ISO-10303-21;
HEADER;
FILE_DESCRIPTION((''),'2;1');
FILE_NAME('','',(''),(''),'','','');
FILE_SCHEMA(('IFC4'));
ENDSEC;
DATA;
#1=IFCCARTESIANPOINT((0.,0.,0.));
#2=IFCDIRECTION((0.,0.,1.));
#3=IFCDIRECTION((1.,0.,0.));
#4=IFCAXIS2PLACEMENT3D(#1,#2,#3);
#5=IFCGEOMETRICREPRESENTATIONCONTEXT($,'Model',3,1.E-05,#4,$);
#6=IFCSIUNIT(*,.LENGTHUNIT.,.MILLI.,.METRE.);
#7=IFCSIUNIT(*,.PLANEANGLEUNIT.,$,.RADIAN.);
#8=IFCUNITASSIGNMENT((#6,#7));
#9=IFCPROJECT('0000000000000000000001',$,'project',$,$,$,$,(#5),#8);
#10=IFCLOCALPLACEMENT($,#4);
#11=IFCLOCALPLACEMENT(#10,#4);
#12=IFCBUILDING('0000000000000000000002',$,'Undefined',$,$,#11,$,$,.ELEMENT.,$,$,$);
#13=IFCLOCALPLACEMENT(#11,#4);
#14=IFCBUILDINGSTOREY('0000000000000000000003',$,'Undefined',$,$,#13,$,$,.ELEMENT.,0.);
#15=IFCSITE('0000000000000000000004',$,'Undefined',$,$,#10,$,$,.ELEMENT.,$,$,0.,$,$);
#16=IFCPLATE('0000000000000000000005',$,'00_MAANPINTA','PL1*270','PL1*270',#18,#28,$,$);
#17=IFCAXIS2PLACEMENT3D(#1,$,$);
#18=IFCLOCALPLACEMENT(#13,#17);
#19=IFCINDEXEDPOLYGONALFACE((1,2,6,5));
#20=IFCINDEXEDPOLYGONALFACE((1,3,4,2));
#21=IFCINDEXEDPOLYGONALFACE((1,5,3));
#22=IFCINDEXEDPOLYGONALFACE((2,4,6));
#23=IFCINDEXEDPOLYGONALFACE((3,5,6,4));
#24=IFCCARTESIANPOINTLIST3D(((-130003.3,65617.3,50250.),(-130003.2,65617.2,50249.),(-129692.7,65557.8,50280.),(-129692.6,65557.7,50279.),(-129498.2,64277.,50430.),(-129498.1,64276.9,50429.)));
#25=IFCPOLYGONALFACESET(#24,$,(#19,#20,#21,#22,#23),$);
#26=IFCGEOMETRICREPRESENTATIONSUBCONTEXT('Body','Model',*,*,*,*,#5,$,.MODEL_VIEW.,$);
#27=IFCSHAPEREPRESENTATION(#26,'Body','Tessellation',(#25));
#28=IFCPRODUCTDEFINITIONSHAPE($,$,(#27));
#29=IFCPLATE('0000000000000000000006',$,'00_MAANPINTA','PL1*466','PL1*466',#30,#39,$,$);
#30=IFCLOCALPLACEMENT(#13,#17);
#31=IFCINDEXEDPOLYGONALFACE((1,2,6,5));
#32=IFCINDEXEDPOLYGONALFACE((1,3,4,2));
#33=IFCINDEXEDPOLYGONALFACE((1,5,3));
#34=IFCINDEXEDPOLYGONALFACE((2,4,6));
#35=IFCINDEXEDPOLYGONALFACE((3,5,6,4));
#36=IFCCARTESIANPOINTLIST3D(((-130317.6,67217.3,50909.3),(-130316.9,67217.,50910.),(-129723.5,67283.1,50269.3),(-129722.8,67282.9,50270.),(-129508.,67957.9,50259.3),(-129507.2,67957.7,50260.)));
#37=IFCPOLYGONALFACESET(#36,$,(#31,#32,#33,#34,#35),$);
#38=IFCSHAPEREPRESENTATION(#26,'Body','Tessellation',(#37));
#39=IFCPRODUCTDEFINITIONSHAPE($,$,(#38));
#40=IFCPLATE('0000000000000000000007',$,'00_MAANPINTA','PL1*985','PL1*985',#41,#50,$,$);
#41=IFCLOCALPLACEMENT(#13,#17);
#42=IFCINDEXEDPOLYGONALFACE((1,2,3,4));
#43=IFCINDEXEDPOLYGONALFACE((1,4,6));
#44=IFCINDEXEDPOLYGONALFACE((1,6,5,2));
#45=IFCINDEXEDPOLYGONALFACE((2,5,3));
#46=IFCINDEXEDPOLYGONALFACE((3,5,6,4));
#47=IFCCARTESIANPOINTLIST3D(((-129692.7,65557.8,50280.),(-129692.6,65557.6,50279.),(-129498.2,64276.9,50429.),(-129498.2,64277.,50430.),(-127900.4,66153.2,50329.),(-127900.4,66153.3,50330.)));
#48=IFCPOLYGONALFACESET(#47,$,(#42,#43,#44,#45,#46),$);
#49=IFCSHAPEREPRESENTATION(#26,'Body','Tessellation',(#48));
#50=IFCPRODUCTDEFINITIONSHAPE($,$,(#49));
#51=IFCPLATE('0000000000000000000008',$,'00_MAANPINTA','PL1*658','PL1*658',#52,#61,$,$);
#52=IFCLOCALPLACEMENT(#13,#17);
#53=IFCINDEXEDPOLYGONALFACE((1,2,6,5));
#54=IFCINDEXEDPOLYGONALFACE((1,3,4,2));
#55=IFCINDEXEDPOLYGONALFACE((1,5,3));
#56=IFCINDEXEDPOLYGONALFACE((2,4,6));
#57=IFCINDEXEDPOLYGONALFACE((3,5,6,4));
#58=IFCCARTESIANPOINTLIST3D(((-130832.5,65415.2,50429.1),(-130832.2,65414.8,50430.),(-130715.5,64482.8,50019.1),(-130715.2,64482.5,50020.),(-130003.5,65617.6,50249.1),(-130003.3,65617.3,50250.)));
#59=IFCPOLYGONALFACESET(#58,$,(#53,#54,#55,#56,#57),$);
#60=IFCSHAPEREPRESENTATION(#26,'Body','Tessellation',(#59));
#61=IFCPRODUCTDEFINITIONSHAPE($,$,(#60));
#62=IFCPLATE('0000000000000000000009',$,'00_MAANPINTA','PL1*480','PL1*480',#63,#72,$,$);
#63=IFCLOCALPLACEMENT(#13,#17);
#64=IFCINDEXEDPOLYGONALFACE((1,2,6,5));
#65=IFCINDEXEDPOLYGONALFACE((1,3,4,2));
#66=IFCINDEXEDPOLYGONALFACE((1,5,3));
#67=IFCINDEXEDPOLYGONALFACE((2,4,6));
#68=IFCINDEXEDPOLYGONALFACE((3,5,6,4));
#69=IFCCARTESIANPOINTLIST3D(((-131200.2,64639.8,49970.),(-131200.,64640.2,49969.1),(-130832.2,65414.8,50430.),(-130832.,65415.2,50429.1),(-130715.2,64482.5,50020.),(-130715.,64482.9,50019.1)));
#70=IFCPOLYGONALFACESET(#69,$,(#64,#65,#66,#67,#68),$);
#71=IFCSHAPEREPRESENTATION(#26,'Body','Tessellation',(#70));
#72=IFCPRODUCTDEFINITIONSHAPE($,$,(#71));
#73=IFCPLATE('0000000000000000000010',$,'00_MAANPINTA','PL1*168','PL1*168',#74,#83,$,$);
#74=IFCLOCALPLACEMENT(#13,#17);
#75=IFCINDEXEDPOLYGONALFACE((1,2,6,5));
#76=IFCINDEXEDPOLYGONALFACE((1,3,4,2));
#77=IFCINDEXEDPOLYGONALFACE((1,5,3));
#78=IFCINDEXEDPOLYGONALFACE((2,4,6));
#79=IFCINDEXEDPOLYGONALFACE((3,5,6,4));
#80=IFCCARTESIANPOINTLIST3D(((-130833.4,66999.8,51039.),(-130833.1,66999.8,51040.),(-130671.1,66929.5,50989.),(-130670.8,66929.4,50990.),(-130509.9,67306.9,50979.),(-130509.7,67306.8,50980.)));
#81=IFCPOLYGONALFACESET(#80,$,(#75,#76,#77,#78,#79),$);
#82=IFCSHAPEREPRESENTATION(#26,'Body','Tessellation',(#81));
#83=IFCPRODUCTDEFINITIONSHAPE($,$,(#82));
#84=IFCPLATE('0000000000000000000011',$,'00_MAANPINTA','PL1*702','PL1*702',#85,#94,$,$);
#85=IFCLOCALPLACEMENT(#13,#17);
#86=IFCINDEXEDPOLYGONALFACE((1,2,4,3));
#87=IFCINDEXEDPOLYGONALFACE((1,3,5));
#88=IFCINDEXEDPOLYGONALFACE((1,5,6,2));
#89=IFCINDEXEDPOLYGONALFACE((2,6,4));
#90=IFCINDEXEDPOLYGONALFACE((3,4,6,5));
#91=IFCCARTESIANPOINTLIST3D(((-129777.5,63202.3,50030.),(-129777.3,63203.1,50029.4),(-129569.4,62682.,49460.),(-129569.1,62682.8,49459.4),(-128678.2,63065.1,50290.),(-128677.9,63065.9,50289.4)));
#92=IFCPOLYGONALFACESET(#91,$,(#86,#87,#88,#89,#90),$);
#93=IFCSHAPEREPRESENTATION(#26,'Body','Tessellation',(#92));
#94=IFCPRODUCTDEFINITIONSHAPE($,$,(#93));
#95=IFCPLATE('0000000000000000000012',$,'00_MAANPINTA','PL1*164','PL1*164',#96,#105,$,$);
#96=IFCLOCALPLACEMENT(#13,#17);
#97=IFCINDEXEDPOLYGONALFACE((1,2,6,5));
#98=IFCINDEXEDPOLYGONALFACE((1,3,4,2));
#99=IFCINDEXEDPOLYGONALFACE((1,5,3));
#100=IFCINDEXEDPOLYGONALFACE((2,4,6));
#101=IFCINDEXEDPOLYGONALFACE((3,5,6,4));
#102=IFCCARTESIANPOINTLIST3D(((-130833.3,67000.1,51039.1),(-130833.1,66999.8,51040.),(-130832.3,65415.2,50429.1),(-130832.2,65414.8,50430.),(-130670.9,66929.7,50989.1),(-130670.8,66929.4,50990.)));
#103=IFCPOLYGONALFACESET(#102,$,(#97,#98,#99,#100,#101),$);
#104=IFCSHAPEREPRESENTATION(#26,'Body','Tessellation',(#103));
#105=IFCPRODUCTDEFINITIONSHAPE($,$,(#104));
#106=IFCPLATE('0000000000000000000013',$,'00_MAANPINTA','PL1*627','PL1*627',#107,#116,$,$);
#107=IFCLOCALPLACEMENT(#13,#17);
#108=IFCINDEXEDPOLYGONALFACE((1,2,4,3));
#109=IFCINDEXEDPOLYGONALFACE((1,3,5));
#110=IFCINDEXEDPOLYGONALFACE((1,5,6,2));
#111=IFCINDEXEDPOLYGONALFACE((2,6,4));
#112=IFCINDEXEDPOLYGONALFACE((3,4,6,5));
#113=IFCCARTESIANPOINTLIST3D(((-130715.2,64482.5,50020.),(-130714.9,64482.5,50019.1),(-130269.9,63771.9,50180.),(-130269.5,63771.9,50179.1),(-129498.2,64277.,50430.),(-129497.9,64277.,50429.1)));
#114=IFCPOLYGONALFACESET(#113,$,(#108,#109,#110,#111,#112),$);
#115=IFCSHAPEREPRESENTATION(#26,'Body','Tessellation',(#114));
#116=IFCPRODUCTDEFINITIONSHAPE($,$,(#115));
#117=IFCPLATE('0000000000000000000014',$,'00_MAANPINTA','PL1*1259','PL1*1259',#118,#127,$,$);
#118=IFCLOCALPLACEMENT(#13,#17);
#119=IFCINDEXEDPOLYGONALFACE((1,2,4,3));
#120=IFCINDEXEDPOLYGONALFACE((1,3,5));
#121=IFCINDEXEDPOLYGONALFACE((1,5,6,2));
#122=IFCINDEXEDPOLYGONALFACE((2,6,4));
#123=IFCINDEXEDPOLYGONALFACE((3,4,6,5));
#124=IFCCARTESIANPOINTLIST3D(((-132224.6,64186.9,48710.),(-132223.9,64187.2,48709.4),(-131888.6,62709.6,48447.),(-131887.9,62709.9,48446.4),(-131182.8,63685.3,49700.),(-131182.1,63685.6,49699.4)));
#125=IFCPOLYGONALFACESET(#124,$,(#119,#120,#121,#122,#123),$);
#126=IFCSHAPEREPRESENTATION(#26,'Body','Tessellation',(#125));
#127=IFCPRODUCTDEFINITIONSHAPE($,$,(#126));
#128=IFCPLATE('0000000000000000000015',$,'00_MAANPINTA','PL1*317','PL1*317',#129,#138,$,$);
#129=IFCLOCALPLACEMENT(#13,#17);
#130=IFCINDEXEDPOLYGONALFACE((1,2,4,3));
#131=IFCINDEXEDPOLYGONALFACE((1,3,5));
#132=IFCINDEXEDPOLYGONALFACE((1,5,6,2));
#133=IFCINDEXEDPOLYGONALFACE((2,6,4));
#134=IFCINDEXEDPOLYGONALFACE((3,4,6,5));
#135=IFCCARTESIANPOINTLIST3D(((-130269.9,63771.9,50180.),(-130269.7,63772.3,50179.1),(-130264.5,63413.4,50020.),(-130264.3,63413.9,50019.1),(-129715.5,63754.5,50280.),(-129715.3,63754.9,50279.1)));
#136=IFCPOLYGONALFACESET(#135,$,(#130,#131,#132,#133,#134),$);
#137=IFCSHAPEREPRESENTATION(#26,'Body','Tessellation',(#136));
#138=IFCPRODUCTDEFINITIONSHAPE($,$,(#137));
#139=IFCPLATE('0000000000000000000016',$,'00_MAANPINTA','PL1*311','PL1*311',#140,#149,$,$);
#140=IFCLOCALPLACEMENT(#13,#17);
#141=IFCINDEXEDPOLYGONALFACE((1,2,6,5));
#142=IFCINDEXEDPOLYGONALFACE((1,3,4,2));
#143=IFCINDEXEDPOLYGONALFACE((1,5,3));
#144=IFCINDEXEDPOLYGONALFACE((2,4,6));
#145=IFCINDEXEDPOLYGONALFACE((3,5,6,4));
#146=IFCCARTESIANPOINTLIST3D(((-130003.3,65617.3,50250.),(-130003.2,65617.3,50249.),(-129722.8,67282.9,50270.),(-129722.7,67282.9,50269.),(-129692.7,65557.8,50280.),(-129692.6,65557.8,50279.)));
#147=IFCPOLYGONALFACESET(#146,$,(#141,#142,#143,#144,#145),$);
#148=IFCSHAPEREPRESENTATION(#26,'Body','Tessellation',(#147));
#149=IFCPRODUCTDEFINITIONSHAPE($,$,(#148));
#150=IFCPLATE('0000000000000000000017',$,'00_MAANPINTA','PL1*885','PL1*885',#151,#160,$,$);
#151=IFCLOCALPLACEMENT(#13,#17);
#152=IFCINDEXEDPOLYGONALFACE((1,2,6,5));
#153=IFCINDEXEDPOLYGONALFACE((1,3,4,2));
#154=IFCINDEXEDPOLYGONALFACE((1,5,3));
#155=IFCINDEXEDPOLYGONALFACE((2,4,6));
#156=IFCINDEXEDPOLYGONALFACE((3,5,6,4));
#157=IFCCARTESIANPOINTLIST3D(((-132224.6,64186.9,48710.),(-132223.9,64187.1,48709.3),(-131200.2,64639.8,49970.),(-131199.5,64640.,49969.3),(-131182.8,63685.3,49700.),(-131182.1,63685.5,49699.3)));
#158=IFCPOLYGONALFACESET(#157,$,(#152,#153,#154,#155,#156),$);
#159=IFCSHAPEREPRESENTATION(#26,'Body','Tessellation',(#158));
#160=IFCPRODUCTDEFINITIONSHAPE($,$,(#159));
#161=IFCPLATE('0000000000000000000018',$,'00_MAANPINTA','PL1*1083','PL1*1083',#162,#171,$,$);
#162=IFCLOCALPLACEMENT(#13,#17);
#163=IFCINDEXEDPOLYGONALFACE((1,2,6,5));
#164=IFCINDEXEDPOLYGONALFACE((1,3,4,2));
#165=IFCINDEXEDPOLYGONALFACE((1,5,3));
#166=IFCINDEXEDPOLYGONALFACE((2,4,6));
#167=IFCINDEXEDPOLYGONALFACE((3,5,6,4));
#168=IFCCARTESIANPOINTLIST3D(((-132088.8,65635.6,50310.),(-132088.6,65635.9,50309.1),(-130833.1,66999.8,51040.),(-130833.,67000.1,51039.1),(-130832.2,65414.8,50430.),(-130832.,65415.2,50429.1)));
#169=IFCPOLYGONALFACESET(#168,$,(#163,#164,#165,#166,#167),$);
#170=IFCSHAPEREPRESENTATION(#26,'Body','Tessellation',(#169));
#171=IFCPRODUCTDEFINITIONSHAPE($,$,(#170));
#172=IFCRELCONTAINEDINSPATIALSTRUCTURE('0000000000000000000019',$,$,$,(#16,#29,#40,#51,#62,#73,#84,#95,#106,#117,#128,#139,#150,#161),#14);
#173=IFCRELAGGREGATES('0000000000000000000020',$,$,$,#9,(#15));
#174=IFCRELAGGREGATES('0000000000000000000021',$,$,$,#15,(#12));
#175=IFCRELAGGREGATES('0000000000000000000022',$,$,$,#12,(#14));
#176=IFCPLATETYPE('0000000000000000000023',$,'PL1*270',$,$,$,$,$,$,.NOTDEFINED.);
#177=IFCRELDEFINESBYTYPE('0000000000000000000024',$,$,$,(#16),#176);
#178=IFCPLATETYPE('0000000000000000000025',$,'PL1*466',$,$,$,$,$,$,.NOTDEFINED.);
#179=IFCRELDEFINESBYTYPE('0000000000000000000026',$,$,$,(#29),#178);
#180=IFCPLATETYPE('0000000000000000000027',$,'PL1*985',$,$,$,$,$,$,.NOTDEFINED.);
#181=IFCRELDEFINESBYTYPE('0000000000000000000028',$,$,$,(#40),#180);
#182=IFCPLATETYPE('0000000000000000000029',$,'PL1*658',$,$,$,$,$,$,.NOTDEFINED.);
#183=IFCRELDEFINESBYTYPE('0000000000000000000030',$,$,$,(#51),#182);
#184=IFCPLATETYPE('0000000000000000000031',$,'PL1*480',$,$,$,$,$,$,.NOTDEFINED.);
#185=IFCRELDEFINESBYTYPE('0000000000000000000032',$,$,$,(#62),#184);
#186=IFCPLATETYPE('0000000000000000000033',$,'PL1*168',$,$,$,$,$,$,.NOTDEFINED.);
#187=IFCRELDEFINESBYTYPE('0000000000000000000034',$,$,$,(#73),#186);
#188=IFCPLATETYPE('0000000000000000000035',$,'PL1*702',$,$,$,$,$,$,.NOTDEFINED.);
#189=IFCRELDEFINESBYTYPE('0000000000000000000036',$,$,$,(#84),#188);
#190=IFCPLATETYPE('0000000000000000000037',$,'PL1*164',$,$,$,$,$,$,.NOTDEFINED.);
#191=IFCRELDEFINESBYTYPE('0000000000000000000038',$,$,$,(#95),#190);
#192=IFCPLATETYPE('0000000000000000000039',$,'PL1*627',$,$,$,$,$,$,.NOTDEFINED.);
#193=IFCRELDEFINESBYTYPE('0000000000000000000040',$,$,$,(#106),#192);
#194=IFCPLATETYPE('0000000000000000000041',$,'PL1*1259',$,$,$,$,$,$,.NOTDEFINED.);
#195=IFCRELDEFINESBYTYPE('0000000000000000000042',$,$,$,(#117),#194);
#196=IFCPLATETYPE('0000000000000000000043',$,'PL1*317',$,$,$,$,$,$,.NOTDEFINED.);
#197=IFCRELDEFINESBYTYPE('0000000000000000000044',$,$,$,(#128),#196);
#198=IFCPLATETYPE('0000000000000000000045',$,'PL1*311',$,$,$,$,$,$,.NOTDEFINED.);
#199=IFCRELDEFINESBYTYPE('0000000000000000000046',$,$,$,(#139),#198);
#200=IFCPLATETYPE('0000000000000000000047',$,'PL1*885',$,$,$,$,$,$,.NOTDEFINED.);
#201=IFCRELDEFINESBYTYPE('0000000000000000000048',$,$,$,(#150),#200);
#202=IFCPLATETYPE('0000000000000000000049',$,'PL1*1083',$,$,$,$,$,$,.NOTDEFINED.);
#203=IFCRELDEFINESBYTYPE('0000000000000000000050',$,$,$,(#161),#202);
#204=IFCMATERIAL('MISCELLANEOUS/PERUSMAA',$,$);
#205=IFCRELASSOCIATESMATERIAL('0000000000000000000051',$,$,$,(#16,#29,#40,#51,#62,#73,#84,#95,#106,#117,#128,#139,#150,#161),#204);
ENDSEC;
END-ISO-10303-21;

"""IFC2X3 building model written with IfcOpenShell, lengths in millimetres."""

from ifc_helpers import new_model, si_unit, frame, origin_with_axes, place, context, subcontext, project, spatial, polyline, outline, extrude, material, type_object, element, save


model = new_model("IFC2X3")

# Units and contexts
model_context = context("Model", 3, precision=1e-05, world=origin_with_axes())
body_context = subcontext(model_context, "Body", "Model", "MODEL_VIEW")
ifc_project = project(units=[si_unit("LENGTHUNIT", "METRE", prefix="MILLI"), si_unit("PLANEANGLEUNIT", "RADIAN")], contexts=[model_context])

# Site, building, storey
site_placement = place(None, origin_with_axes())
site = spatial("IfcSite", under=ifc_project, at=site_placement, Name="Undefined", CompositionType="ELEMENT", RefElevation=0.0)
building_placement = place(site_placement, origin_with_axes())
building = spatial("IfcBuilding", under=site, at=building_placement, Name="Undefined", CompositionType="ELEMENT")
storey_placement = place(building_placement, origin_with_axes())
storey = spatial("IfcBuildingStorey", under=building, at=storey_placement, Name="Undefined", CompositionType="ELEMENT", Elevation=0.0)

# Plates
ifc_material = material(Name="MISCELLANEOUS/PERUSMAA")
plate_type_1 = type_object("IfcPlateType", Name="PL1*270", PredefinedType="NOTDEFINED")
plate_1_placement = place(storey_placement, frame((-130003.2, 65617.2, 50249.5), z_axis=(0.075738, -0.104639, -0.991622), x_axis=(0.977749, -0.187314, 0.094444)))
element("IfcPlate", 1, at=plate_1_placement, inside=storey, type_object=plate_type_1, material=ifc_material, Name="00_MAANPINTA", Description="PL1*270", ObjectType="PL1*270", context=body_context, shape_type="SweptSolid", body=[
    extrude(outline(polyline([(0.0, 0.0), (317.6, 0.0), (761.9, 1226.1), (0.0, 0.0)])), frame((0.0, 0.0, -0.5), z_axis=(0.0, 0.0, 1.0), x_axis=(1.0, 0.0, 0.0)), (0.0, 0.0, 1.0), 1.0),
])
plate_type_2 = type_object("IfcPlateType", Name="PL1*466", PredefinedType="NOTDEFINED")
plate_2_placement = place(storey_placement, frame((-130317.3, 67217.2, 50909.7), z_axis=(-0.725863, 0.222234, -0.650949), x_axis=(0.634846, 0.580712, -0.509651)))
element("IfcPlate", 2, at=plate_2_placement, inside=storey, type_object=plate_type_2, material=ifc_material, Name="00_MAANPINTA", Description="PL1*466", ObjectType="PL1*466", context=body_context, shape_type="SweptSolid", body=[
    extrude(outline(polyline([(0.0, 0.0), (1275.4, 0.0), (741.6, 465.8), (0.0, 0.0)])), frame((0.0, 0.0, -0.5), z_axis=(0.0, 0.0, 1.0), x_axis=(1.0, 0.0, 0.0)), (0.0, 0.0, 1.0), 1.0),
])
plate_type_3 = type_object("IfcPlateType", Name="PL1*985", PredefinedType="NOTDEFINED")
plate_3_placement = place(storey_placement, frame((-129498.2, 64277.0, 50429.5), z_axis=(0.063116, -0.106634, -0.992293), x_axis=(-0.14912, 0.982106, -0.115024)))
element("IfcPlate", 3, at=plate_3_placement, inside=storey, type_object=plate_type_3, material=ifc_material, Name="00_MAANPINTA", Description="PL1*985", ObjectType="PL1*985", context=body_context, shape_type="SweptSolid", body=[
    extrude(outline(polyline([(0.0, 0.0), (1304.1, 0.0), (1615.9, 1863.3), (0.0, 0.0)])), frame((0.0, 0.0, -0.5), z_axis=(0.0, 0.0, 1.0), x_axis=(1.0, 0.0, 0.0)), (0.0, 0.0, 1.0), 1.0),
])
plate_type_4 = type_object("IfcPlateType", Name="PL1*658", PredefinedType="NOTDEFINED")
plate_4_placement = place(storey_placement, frame((-130715.4, 64482.7, 50019.6), z_axis=(-0.280613, 0.356665, -0.891093), x_axis=(-0.114092, 0.909417, 0.399929)))
element("IfcPlate", 4, at=plate_4_placement, inside=storey, type_object=plate_type_4, material=ifc_material, Name="00_MAANPINTA", Description="PL1*658", ObjectType="PL1*658", context=body_context, shape_type="SweptSolid", body=[
    extrude(outline(polyline([(0.0, 0.0), (1025.2, 0.0), (1042.7, 871.9), (0.0, 0.0)])), frame((0.0, 0.0, -0.5), z_axis=(0.0, 0.0, 1.0), x_axis=(1.0, 0.0, 0.0)), (0.0, 0.0, 1.0), 1.0),
])
plate_type_5 = type_object("IfcPlateType", Name="PL1*480", PredefinedType="NOTDEFINED")
plate_5_placement = place(storey_placement, frame((-130832.1, 65415.0, 50429.6), z_axis=(0.225672, 0.415758, -0.881032), x_axis=(0.114092, -0.909417, -0.399929)))
element("IfcPlate", 5, at=plate_5_placement, inside=storey, type_object=plate_type_5, material=ifc_material, Name="00_MAANPINTA", Description="PL1*480", ObjectType="PL1*480", context=body_context, shape_type="SweptSolid", body=[
    extrude(outline(polyline([(0.0, 0.0), (1025.2, 0.0), (846.8, 480.3), (0.0, 0.0)])), frame((0.0, 0.0, -0.5), z_axis=(0.0, 0.0, 1.0), x_axis=(1.0, 0.0, 0.0)), (0.0, 0.0, 1.0), 1.0),
])
plate_type_6 = type_object("IfcPlateType", Name="PL1*168", PredefinedType="NOTDEFINED")
plate_6_placement = place(storey_placement, frame((-130670.9, 66929.4, 50989.5), z_axis=(-0.259364, 0.085271, -0.962008), x_axis=(-0.882891, 0.382804, 0.271964)))
element("IfcPlate", 6, at=plate_6_placement, inside=storey, type_object=plate_type_6, material=ifc_material, Name="00_MAANPINTA", Description="PL1*168", ObjectType="PL1*168", context=body_context, shape_type="SweptSolid", body=[
    extrude(outline(polyline([(0.0, 0.0), (183.8, 0.0), (-0.5, 410.5), (0.0, 0.0)])), frame((0.0, 0.0, -0.5), z_axis=(0.0, 0.0, 1.0), x_axis=(1.0, 0.0, 0.0)), (0.0, 0.0, 1.0), 1.0),
])
plate_type_7 = type_object("IfcPlateType", Name="PL1*702", PredefinedType="NOTDEFINED")
plate_7_placement = place(storey_placement, frame((-129569.3, 62682.4, 49459.7), z_axis=(0.238036, 0.759075, -0.605924), x_axis=(-0.260399, 0.650893, 0.713113)))
element("IfcPlate", 7, at=plate_7_placement, inside=storey, type_object=plate_type_7, material=ifc_material, Name="00_MAANPINTA", Description="PL1*702", ObjectType="PL1*702", context=body_context, shape_type="SweptSolid", body=[
    extrude(outline(polyline([(0.0, 0.0), (799.3, 0.0), (609.1, 1122.0), (0.0, 0.0)])), frame((0.0, 0.0, -0.5), z_axis=(0.0, 0.0, 1.0), x_axis=(1.0, 0.0, 0.0)), (0.0, 0.0, 1.0), 1.0),
])
plate_type_8 = type_object("IfcPlateType", Name="PL1*164", PredefinedType="NOTDEFINED")
plate_8_placement = place(storey_placement, frame((-130833.2, 66999.9, 51039.5), z_axis=(-0.130655, 0.356037, -0.925293), x_axis=(0.882891, -0.382804, -0.271964)))
element("IfcPlate", 8, at=plate_8_placement, inside=storey, type_object=plate_type_8, material=ifc_material, Name="00_MAANPINTA", Description="PL1*164", ObjectType="PL1*164", context=body_context, shape_type="SweptSolid", body=[
    extrude(outline(polyline([(0.0, 0.0), (183.8, 0.0), (773.5, 1511.9), (0.0, 0.0)])), frame((0.0, 0.0, -0.5), z_axis=(0.0, 0.0, 1.0), x_axis=(1.0, 0.0, 0.0)), (0.0, 0.0, 1.0), 1.0),
])
plate_type_9 = type_object("IfcPlateType", Name="PL1*627", PredefinedType="NOTDEFINED")
plate_9_placement = place(storey_placement, frame((-130269.7, 63771.9, 50179.5), z_axis=(0.316973, -0.014867, -0.948318), x_axis=(-0.521645, 0.832325, -0.187407)))
element("IfcPlate", 9, at=plate_9_placement, inside=storey, type_object=plate_type_9, material=ifc_material, Name="00_MAANPINTA", Description="PL1*627", ObjectType="PL1*627", context=body_context, shape_type="SweptSolid", body=[
    extrude(outline(polyline([(0.0, 0.0), (853.8, 0.0), (-28.9, 955.1), (0.0, 0.0)])), frame((0.0, 0.0, -0.5), z_axis=(0.0, 0.0, 1.0), x_axis=(1.0, 0.0, 0.0)), (0.0, 0.0, 1.0), 1.0),
])
plate_type_10 = type_object("IfcPlateType", Name="PL1*1259", PredefinedType="NOTDEFINED")
plate_10_placement = place(storey_placement, frame((-131182.5, 63685.5, 49699.7), z_axis=(0.728638, 0.277233, -0.626282), x_axis=(-0.406112, -0.561438, -0.721014)))
element("IfcPlate", 10, at=plate_10_placement, inside=storey, type_object=plate_type_10, material=ifc_material, Name="00_MAANPINTA", Description="PL1*1259", ObjectType="PL1*1259", context=body_context, shape_type="SweptSolid", body=[
    extrude(outline(polyline([(0.0, 0.0), (1737.8, 0.0), (855.3, 1259.2), (0.0, 0.0)])), frame((0.0, 0.0, -0.5), z_axis=(0.0, 0.0, 1.0), x_axis=(1.0, 0.0, 0.0)), (0.0, 0.0, 1.0), 1.0),
])
plate_type_11 = type_object("IfcPlateType", Name="PL1*317", PredefinedType="NOTDEFINED")
plate_11_placement = place(storey_placement, frame((-129715.4, 63754.7, 50279.6), z_axis=(0.174636, 0.403548, -0.898138), x_axis=(-0.788014, -0.489632, -0.373223)))
element("IfcPlate", 11, at=plate_11_placement, inside=storey, type_object=plate_type_11, material=ifc_material, Name="00_MAANPINTA", Description="PL1*317", ObjectType="PL1*317", context=body_context, shape_type="SweptSolid", body=[
    extrude(outline(polyline([(0.0, 0.0), (696.6, 0.0), (465.7, 317.4), (0.0, 0.0)])), frame((0.0, 0.0, -0.5), z_axis=(0.0, 0.0, 1.0), x_axis=(1.0, 0.0, 0.0)), (0.0, 0.0, 1.0), 1.0),
])
plate_type_12 = type_object("IfcPlateType", Name="PL1*311", PredefinedType="NOTDEFINED")
plate_12_placement = place(storey_placement, frame((-129722.8, 67282.9, 50269.5), z_axis=(0.095366, -0.004105, -0.995434), x_axis=(0.017456, -0.999831, 0.005796)))
element("IfcPlate", 12, at=plate_12_placement, inside=storey, type_object=plate_type_12, material=ifc_material, Name="00_MAANPINTA", Description="PL1*311", ObjectType="PL1*311", context=body_context, shape_type="SweptSolid", body=[
    extrude(outline(polyline([(0.0, 0.0), (1725.4, 0.0), (1660.3, 310.9), (0.0, 0.0)])), frame((0.0, 0.0, -0.5), z_axis=(0.0, 0.0, 1.0), x_axis=(1.0, 0.0, 0.0)), (0.0, 0.0, 1.0), 1.0),
])
plate_type_13 = type_object("IfcPlateType", Name="PL1*885", PredefinedType="NOTDEFINED")
plate_13_placement = place(storey_placement, frame((-131182.5, 63685.4, 49699.7), z_axis=(0.723832, 0.20001, -0.660351), x_axis=(-0.684403, 0.329527, -0.650387)))
element("IfcPlate", 13, at=plate_13_placement, inside=storey, type_object=plate_type_13, material=ifc_material, Name="00_MAANPINTA", Description="PL1*885", ObjectType="PL1*885", context=body_context, shape_type="SweptSolid", body=[
    extrude(outline(polyline([(0.0, 0.0), (1522.2, 0.0), (150.8, 980.5), (0.0, 0.0)])), frame((0.0, 0.0, -0.5), z_axis=(0.0, 0.0, 1.0), x_axis=(1.0, 0.0, 0.0)), (0.0, 0.0, 1.0), 1.0),
])
plate_type_14 = type_object("IfcPlateType", Name="PL1*1083", PredefinedType="NOTDEFINED")
plate_14_placement = place(storey_placement, frame((-130832.1, 65415.0, 50429.5), z_axis=(0.150507, 0.355171, -0.922606), x_axis=(-0.980587, 0.17228, -0.093644)))
element("IfcPlate", 14, at=plate_14_placement, inside=storey, type_object=plate_type_14, material=ifc_material, Name="00_MAANPINTA", Description="PL1*1083", ObjectType="PL1*1083", context=body_context, shape_type="SweptSolid", body=[
    extrude(outline(polyline([(0.0, 0.0), (1281.4, 0.0), (216.9, 1684.4), (0.0, 0.0)])), frame((0.0, 0.0, -0.5), z_axis=(0.0, 0.0, 1.0), x_axis=(1.0, 0.0, 0.0)), (0.0, 0.0, 1.0), 1.0),
])

save(model, "model.ifc")
